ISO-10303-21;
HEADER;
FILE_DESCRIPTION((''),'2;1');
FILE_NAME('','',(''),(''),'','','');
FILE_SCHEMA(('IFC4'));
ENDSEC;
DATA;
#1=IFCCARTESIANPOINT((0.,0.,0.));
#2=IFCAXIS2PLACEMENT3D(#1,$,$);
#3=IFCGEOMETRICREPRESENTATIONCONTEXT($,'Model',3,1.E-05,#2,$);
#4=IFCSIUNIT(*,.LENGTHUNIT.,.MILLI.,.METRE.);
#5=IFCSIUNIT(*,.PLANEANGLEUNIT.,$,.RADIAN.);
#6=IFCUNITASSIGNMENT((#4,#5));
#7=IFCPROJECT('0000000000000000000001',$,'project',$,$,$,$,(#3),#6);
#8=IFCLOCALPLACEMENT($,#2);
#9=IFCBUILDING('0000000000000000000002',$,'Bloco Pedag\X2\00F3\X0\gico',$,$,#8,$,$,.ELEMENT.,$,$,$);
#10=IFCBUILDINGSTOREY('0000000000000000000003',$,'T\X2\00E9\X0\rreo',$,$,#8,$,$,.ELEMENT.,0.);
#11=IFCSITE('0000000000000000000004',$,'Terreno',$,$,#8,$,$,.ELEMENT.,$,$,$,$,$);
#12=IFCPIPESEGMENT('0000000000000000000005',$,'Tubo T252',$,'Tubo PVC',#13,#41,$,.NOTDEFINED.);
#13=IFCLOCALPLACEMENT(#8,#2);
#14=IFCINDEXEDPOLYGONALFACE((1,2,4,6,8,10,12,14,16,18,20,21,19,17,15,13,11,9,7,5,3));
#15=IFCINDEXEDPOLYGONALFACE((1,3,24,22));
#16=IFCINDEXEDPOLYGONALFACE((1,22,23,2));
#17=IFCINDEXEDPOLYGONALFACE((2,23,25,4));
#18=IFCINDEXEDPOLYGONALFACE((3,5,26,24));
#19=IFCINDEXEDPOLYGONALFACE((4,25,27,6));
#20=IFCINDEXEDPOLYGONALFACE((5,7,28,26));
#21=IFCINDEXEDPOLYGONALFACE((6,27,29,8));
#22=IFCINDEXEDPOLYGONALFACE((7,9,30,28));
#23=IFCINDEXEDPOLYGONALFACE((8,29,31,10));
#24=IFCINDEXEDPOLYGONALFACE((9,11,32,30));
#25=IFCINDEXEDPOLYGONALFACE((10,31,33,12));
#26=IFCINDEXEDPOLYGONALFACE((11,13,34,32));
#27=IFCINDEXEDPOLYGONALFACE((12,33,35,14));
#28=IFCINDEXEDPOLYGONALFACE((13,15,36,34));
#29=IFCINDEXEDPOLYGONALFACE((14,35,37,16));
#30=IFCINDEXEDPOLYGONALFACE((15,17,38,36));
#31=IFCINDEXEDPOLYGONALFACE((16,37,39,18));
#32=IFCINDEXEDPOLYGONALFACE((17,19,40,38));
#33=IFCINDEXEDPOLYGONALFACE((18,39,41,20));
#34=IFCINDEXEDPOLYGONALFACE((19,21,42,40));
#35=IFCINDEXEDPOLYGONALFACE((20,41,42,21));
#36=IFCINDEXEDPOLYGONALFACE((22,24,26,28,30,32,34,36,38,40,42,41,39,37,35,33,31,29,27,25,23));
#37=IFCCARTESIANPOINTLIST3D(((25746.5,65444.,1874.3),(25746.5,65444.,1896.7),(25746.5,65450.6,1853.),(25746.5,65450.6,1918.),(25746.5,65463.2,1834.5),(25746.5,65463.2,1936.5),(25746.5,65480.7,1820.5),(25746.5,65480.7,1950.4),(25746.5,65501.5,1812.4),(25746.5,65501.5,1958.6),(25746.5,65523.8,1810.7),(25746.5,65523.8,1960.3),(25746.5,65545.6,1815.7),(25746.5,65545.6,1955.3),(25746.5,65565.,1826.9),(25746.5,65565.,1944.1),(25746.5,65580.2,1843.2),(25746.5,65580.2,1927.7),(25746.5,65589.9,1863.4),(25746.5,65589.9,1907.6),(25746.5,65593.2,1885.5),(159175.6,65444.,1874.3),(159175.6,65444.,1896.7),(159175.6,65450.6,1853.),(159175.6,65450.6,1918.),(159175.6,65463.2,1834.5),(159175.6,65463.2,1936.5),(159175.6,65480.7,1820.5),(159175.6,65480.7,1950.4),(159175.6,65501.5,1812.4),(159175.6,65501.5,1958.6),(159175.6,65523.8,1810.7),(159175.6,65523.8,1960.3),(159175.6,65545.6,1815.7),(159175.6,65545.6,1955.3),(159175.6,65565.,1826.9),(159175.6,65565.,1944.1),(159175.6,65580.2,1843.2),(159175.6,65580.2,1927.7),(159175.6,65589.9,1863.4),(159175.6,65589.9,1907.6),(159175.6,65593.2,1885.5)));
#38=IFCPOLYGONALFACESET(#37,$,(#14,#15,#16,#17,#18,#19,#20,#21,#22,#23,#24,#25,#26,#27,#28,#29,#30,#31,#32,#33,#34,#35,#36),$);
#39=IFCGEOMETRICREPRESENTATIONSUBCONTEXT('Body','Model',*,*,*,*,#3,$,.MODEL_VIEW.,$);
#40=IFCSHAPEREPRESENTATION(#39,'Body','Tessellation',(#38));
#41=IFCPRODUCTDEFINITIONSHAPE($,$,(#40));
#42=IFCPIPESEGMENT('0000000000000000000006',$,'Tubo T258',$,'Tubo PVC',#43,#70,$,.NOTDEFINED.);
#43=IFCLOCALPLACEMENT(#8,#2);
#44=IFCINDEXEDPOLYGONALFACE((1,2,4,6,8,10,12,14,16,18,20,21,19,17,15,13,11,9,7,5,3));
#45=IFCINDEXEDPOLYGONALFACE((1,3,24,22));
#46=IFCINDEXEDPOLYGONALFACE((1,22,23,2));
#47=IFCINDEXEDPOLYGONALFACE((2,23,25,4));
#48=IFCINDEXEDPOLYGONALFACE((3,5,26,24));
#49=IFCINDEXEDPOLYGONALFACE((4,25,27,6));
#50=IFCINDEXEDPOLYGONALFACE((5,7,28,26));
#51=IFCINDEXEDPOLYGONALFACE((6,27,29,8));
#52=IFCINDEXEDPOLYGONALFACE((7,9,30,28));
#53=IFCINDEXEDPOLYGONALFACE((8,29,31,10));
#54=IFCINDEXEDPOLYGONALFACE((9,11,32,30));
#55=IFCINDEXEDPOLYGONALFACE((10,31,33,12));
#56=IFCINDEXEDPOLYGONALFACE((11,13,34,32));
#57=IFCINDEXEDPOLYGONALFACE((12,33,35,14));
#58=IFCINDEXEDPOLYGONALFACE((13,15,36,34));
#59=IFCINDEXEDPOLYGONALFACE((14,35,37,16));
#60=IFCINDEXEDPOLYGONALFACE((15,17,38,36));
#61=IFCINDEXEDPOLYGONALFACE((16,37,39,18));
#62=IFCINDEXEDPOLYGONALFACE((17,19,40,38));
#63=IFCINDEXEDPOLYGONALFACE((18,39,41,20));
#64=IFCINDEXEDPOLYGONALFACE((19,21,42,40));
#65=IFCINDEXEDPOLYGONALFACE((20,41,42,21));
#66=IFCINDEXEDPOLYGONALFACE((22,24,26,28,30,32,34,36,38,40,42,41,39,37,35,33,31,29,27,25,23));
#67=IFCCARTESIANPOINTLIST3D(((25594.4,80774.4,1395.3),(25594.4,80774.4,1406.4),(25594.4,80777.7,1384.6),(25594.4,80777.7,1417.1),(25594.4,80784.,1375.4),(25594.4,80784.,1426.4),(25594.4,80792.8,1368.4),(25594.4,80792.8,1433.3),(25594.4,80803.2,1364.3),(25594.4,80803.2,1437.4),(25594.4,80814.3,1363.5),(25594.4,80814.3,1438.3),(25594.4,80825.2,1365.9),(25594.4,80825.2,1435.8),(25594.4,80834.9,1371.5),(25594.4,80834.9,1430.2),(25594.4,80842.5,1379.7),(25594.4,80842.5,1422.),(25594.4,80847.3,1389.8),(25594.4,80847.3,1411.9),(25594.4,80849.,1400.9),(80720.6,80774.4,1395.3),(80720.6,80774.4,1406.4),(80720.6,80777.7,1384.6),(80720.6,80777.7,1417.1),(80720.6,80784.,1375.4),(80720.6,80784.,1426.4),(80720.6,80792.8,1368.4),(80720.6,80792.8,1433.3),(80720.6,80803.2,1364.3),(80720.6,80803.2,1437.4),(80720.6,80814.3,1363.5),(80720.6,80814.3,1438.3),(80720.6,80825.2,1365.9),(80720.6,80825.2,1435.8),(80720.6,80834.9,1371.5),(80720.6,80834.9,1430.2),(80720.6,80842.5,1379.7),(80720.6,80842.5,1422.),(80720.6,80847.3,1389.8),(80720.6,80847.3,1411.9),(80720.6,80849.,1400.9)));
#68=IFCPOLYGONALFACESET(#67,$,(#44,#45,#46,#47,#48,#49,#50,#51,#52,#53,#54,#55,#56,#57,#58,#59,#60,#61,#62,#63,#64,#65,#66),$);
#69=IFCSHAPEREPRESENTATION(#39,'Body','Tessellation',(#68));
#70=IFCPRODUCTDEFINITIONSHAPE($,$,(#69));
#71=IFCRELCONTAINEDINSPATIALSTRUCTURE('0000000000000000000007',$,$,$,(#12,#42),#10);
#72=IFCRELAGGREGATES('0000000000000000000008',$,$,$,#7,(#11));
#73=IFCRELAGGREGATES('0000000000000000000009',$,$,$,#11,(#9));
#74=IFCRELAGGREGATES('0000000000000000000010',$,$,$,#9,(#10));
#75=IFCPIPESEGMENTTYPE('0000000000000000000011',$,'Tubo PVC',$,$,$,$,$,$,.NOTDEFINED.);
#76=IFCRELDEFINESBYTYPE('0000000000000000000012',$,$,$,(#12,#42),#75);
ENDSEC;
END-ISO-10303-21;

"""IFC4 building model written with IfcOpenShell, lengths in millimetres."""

from ifc_helpers import new_model, si_unit, frame, origin, origin_2d, place, context, subcontext, project, spatial, circle, extrude, type_object, element, save


model = new_model("IFC4")

# Units and contexts
model_context = context("Model", 3, precision=1e-05, world=origin())
body_context = subcontext(model_context, "Body", "Model", "MODEL_VIEW")
ifc_project = project(units=[si_unit("LENGTHUNIT", "METRE", prefix="MILLI"), si_unit("PLANEANGLEUNIT", "RADIAN")], contexts=[model_context])

# Site, building, storey
placement = place(None, origin())
site = spatial("IfcSite", under=ifc_project, at=placement, Name="Terreno", CompositionType="ELEMENT")
building = spatial("IfcBuilding", under=site, at=placement, Name="Bloco Pedagógico", CompositionType="ELEMENT")
storey = spatial("IfcBuildingStorey", under=building, at=placement, Name="Térreo", CompositionType="ELEMENT", Elevation=0.0)

# Pipe segments
pipe_segment_type = type_object("IfcPipeSegmentType", Name="Tubo PVC", PredefinedType="NOTDEFINED")
pipe_segment_1_placement = place(None, frame((25746.5, 65518.2, 1885.5), z_axis=(1.0, 0.0, 0.0), x_axis=(0.0, 1.0, 0.0)))
element("IfcPipeSegment", 1, at=pipe_segment_1_placement, inside=storey, type_object=pipe_segment_type, Name="Tubo T252", ObjectType="Tubo PVC", PredefinedType="NOTDEFINED", context=body_context, shape_type="SweptSolid", body=[
    extrude(circle(Radius=75.0, at=origin_2d()), None, (0.0, 0.0, 1.0), 133429.1),
])
pipe_segment_2_placement = place(None, frame((25594.4, 80811.5, 1400.9), z_axis=(1.0, 0.0, 0.0), x_axis=(0.0, 1.0, 0.0)))
element("IfcPipeSegment", 2, at=pipe_segment_2_placement, inside=storey, type_object=pipe_segment_type, Name="Tubo T258", ObjectType="Tubo PVC", PredefinedType="NOTDEFINED", context=body_context, shape_type="SweptSolid", body=[
    extrude(circle(Radius=37.5, at=origin_2d()), None, (0.0, 0.0, 1.0), 55126.3),
])

save(model, "model.ifc")
